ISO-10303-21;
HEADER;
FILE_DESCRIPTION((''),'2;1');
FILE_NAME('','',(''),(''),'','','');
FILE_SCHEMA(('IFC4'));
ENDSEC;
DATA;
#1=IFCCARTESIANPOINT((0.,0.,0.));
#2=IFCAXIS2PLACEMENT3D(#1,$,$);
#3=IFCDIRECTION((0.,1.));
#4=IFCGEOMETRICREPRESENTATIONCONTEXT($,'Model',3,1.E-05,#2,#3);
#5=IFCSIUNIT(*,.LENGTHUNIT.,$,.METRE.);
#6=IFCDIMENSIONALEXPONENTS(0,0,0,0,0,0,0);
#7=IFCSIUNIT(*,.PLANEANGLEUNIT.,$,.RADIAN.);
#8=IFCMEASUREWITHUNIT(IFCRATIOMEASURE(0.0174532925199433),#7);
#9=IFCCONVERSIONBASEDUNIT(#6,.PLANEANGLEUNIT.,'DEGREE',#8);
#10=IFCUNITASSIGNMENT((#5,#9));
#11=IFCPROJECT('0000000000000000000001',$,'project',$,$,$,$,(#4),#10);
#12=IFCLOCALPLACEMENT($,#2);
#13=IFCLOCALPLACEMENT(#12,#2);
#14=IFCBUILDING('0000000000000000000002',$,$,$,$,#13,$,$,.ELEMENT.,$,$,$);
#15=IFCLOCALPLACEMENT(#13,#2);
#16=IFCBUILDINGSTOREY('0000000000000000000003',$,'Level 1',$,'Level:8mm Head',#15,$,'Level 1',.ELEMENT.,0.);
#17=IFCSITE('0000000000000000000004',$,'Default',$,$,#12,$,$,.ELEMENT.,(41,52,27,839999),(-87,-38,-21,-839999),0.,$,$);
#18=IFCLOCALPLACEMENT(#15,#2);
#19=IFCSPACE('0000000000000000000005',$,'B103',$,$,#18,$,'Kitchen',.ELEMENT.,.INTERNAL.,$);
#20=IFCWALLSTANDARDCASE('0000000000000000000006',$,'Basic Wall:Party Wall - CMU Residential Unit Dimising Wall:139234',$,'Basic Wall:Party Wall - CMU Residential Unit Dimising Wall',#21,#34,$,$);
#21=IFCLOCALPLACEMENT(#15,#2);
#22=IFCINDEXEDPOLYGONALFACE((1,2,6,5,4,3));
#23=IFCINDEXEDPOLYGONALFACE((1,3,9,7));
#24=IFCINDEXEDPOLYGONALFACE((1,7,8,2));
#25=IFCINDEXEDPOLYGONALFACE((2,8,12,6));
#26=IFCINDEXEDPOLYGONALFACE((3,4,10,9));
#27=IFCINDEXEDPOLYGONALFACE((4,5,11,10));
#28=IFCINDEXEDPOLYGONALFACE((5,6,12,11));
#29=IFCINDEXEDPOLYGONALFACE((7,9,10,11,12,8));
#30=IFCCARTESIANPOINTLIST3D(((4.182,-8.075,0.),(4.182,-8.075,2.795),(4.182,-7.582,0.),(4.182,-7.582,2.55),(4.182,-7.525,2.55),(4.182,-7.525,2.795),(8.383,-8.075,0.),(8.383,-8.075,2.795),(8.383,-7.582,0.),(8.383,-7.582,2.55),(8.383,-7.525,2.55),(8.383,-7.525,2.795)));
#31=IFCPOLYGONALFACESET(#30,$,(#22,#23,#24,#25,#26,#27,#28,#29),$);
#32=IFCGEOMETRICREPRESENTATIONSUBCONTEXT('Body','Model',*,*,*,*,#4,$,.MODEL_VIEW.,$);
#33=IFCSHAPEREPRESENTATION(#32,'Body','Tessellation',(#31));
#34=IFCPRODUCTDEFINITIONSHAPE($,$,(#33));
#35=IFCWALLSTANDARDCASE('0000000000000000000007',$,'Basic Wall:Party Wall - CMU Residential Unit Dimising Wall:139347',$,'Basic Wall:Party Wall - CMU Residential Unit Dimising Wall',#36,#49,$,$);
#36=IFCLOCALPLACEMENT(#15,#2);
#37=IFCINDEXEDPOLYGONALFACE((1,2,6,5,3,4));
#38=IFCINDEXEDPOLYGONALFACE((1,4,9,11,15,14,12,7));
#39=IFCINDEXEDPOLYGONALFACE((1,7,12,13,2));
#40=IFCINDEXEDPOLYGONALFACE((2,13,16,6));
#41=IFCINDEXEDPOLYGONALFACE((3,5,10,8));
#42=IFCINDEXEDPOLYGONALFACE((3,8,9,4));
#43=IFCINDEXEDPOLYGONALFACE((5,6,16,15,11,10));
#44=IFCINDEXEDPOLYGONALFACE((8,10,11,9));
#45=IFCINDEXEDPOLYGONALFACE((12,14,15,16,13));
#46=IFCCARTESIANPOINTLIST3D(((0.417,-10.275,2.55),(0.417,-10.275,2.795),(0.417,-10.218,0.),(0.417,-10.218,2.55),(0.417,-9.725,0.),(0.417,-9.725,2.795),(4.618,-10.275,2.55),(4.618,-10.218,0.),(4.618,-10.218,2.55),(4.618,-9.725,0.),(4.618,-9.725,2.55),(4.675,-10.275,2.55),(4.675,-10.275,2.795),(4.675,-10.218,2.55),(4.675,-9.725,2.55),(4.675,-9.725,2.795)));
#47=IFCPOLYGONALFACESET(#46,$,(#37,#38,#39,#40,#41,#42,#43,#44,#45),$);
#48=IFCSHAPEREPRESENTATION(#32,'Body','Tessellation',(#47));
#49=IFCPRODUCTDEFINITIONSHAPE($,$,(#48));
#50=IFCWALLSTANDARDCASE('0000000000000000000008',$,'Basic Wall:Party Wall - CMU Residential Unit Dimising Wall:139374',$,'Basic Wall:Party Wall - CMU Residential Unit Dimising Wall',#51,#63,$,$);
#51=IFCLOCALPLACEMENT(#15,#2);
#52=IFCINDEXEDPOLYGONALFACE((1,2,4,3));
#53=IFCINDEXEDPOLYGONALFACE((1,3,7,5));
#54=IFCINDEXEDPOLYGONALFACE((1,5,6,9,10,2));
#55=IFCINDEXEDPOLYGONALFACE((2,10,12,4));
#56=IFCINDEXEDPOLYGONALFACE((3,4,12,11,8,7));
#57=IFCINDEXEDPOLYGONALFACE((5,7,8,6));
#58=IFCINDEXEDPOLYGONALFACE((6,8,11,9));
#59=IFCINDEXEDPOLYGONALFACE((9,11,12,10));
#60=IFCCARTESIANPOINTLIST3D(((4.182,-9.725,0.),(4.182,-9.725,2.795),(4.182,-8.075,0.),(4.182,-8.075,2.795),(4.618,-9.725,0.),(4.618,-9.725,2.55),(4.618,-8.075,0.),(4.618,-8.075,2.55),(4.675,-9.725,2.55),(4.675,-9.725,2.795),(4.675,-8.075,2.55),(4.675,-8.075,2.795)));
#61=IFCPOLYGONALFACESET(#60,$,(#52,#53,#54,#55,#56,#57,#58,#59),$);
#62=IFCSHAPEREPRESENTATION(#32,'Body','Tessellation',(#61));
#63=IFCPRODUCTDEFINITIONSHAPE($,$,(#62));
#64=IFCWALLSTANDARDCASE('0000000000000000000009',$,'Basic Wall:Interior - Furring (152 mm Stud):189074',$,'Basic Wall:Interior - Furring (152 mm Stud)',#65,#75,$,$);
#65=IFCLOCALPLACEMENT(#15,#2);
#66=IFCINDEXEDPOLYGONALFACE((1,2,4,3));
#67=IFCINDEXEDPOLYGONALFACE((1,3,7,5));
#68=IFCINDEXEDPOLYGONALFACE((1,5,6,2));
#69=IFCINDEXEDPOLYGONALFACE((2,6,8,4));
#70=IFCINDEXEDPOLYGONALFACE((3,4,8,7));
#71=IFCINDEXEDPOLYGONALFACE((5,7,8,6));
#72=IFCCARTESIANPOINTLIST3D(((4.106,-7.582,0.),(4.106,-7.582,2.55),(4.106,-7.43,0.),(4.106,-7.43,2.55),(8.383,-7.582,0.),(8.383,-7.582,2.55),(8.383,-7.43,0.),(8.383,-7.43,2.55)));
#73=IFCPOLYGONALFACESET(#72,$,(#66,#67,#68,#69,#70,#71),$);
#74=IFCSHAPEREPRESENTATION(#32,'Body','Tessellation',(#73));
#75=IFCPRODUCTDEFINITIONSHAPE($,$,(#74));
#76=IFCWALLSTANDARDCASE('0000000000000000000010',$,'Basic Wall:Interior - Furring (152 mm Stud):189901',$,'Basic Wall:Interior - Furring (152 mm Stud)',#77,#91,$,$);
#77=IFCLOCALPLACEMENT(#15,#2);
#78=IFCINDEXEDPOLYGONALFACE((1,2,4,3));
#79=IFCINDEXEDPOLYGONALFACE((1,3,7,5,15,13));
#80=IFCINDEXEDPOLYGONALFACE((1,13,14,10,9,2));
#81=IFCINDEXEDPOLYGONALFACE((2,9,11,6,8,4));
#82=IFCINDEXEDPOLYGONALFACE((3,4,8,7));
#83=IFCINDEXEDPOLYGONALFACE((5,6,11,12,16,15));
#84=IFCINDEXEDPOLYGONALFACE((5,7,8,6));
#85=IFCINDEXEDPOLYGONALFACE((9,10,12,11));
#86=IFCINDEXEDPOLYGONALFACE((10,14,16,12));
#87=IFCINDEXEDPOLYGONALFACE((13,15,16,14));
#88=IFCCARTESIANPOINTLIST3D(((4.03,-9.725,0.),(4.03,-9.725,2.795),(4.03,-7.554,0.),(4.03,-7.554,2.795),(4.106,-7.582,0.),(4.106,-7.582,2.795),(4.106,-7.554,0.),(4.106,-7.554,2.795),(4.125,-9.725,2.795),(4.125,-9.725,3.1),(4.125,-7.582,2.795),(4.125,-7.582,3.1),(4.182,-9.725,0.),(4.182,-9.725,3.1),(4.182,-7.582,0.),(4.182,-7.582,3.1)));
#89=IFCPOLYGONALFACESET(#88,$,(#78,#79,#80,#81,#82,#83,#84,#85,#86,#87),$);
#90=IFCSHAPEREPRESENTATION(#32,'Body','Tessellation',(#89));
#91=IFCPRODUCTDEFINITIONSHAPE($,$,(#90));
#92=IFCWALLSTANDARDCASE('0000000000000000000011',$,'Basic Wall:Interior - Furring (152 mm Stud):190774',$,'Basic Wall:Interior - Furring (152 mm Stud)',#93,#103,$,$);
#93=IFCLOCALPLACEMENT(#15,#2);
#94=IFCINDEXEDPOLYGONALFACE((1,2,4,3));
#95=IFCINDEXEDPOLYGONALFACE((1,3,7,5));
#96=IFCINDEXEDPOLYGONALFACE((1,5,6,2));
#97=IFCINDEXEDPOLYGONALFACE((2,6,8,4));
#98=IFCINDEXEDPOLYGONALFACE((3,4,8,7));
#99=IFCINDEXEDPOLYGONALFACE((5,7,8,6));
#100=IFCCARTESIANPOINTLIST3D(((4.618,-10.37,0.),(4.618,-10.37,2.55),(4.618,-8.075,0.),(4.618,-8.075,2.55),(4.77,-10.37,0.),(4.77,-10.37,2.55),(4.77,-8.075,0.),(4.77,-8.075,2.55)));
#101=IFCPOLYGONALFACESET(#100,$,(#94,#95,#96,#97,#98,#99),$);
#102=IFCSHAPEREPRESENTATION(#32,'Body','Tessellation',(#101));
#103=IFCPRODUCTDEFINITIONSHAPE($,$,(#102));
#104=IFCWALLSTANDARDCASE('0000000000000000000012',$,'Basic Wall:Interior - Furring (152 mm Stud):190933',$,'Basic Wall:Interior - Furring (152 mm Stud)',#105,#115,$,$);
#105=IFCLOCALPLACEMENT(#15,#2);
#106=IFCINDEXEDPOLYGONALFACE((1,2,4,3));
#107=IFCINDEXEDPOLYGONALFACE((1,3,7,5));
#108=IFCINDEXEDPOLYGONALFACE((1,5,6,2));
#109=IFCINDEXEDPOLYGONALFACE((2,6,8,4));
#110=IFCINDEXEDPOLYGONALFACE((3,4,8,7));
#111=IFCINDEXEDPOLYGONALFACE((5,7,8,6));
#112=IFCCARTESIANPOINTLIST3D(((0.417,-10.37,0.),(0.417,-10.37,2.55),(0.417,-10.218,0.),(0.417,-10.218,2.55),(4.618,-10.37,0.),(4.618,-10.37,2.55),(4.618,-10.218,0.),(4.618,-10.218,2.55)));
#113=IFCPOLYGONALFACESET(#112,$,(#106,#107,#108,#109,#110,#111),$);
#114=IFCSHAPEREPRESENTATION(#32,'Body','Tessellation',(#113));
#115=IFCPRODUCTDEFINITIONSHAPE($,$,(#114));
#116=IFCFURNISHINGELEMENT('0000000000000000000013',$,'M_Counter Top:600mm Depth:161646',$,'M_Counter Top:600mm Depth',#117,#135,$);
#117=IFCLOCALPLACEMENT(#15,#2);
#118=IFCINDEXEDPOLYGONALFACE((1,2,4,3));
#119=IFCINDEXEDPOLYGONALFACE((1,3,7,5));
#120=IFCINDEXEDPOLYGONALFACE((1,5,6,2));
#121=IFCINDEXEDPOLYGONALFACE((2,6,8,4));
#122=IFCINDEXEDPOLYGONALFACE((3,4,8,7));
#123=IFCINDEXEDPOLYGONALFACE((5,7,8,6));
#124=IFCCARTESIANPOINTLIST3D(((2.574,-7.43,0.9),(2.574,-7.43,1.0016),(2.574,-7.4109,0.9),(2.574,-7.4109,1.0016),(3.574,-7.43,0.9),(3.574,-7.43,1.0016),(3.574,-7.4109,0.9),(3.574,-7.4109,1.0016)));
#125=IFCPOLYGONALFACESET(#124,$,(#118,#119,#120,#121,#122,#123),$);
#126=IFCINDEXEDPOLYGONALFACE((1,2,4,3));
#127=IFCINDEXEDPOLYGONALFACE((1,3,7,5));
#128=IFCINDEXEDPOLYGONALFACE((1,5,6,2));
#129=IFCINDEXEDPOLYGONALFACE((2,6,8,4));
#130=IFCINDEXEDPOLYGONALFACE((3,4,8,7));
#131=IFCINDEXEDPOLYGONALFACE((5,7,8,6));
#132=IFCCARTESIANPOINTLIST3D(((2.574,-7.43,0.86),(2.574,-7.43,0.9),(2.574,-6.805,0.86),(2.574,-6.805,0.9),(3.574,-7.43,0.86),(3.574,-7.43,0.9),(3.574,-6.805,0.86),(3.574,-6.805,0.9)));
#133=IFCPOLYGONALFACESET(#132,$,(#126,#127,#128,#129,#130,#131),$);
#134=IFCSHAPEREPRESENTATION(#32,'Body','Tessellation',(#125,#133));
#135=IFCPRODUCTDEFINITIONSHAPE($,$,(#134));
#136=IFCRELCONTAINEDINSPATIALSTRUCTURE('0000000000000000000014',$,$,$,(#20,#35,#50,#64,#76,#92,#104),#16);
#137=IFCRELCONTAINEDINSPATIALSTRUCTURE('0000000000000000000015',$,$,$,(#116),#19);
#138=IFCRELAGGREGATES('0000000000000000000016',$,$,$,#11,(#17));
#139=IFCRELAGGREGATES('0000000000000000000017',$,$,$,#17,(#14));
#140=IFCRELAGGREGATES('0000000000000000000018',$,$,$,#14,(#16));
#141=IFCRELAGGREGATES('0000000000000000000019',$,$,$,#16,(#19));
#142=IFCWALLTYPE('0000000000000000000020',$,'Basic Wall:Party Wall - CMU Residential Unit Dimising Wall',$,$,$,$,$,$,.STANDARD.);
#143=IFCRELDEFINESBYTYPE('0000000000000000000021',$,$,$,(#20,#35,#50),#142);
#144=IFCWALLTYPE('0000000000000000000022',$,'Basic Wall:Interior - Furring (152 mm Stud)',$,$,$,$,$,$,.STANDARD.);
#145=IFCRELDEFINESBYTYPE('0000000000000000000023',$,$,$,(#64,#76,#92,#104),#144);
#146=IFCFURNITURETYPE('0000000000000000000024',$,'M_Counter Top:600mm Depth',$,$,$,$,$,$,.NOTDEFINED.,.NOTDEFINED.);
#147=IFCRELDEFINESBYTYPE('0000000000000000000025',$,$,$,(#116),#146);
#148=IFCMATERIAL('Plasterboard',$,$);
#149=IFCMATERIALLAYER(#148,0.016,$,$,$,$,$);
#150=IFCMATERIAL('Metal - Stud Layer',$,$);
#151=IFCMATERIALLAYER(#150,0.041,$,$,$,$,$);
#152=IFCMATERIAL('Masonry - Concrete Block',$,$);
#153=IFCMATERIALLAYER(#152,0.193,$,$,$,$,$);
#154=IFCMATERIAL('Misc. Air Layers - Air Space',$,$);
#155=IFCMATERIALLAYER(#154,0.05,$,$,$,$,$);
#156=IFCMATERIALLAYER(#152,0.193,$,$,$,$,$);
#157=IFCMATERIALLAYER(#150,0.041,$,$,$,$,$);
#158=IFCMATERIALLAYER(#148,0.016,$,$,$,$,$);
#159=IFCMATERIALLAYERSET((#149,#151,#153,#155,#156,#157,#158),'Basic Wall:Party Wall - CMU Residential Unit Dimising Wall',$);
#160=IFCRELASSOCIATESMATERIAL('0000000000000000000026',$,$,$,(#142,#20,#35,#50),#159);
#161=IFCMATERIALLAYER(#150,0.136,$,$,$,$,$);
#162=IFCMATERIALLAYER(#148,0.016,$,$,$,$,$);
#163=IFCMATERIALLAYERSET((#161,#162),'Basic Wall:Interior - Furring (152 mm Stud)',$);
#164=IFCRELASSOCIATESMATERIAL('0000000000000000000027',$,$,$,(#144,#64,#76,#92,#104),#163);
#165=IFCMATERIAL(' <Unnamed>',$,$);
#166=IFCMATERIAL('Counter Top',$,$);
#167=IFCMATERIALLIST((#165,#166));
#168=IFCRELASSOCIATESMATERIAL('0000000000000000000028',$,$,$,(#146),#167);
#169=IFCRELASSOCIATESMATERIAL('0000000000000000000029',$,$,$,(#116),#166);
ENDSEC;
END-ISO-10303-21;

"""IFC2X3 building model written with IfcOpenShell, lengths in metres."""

from ifc_helpers import new_model, entity, si_unit, converted_unit, direction, frame, frame_2d, origin, place, context, subcontext, project, spatial, polyline, rectangle, outline, extrude, clip, bounded_halfspace, source, transform, mapped, material, material_list, layer, layer_set, layer_usage, type_object, type_shapes, element, save


model = new_model("IFC2X3")

# Units and contexts
model_context = context("Model", 3, precision=1e-05, world=origin(), true_north=direction((0.0, 1.0)))
body_context = subcontext(model_context, "Body", "Model", "MODEL_VIEW")
ifc_project = project(units=[si_unit("LENGTHUNIT", "METRE"), converted_unit("PLANEANGLEUNIT", "DEGREE", entity("IfcRatioMeasure", 0.0174532925199433), si_unit("PLANEANGLEUNIT", "RADIAN"), dimensions=[0, 0, 0, 0, 0, 0, 0])], contexts=[model_context])

# Site, building, storey
site_placement = place(None, origin())
site = spatial("IfcSite", under=ifc_project, at=site_placement, Name="Default", CompositionType="ELEMENT", RefLatitude=(41, 52, 27, 839999), RefLongitude=(-87, -38, -21, -839999), RefElevation=0.0)
building_placement = place(site_placement, origin())
building = spatial("IfcBuilding", under=site, at=building_placement, CompositionType="ELEMENT")
storey_placement = place(building_placement, origin())
storey = spatial("IfcBuildingStorey", under=building, at=storey_placement, Name="Level 1", ObjectType="Level:8mm Head", LongName="Level 1", CompositionType="ELEMENT", Elevation=0.0)

# Shared definitions
ifc_material_1 = material(Name="Misc. Air Layers - Air Space")
ifc_material_2 = material(Name="Masonry - Concrete Block")
ifc_material_3 = material(Name="Metal - Stud Layer")
ifc_material_4 = material(Name="Plasterboard")

# Walls
ifc_layer_1 = layer(ifc_material_4, 0.016)
ifc_layer_2 = layer(ifc_material_3, 0.041)
ifc_layer_3 = layer(ifc_material_2, 0.193)
ifc_layer_4 = layer(ifc_material_1, 0.05)
ifc_layer_5 = layer(ifc_material_2, 0.193)
ifc_layer_6 = layer(ifc_material_3, 0.041)
ifc_layer_7 = layer(ifc_material_4, 0.016)
ifc_layer_set_1 = layer_set([ifc_layer_1, ifc_layer_2, ifc_layer_3, ifc_layer_4, ifc_layer_5, ifc_layer_6, ifc_layer_7], Name="Basic Wall:Party Wall - CMU Residential Unit Dimising Wall")
ifc_layer_usage_1 = layer_usage(ifc_layer_set_1, "AXIS2", "NEGATIVE", 0.275)
wall_type_1 = type_object("IfcWallType", Name="Basic Wall:Party Wall - CMU Residential Unit Dimising Wall", PredefinedType="STANDARD", material=ifc_layer_set_1)
wall_1_placement = place(storey_placement, frame((8.383, -7.8, 0.0), z_axis=(0.0, 0.0, 1.0), x_axis=(-1.0, 0.0, 0.0)))
element("IfcWallStandardCase", 1, at=wall_1_placement, inside=storey, type_object=wall_type_1, material=ifc_layer_usage_1, Name="Basic Wall:Party Wall - CMU Residential Unit Dimising Wall:139234", ObjectType="Basic Wall:Party Wall - CMU Residential Unit Dimising Wall", context=body_context, shape_type="Clipping", body=[
    clip(clip(extrude(rectangle(XDim=4.201, YDim=0.55, at=frame_2d((2.1005, 0.0), x_axis=(-1.0, 0.0))), origin(), (0.0, 0.0, 1.0), 2.795), bounded_halfspace(frame((4.201, -0.218, 2.55), z_axis=(0.0, 1.0, 0.0), x_axis=(-1.0, 0.0, 0.0)), True, frame((4.201, -0.218, 2.55), z_axis=(0.0, 1.0, 0.0), x_axis=(-1.0, 0.0, 0.0)), polyline([(0.0, 0.0), (0.0, -2.55), (4.201, -2.55), (4.201, 0.0), (0.0, 0.0)]))), bounded_halfspace(frame((0.0, -0.218, 2.55), z_axis=(0.0, 0.0, 1.0), x_axis=(0.0, 1.0, 0.0)), True, frame((0.0, -0.218, 2.55), z_axis=(0.0, 0.0, 1.0), x_axis=(0.0, 1.0, 0.0)), polyline([(0.0, 0.0), (-0.057, 0.0), (-0.057, -4.201), (0.0, -4.201), (0.0, 0.0)]))),
])
ifc_layer_usage_2 = layer_usage(ifc_layer_set_1, "AXIS2", "NEGATIVE", 0.275)
wall_2_placement = place(storey_placement, frame((0.417, -10.0, 0.0)))
element("IfcWallStandardCase", 2, at=wall_2_placement, inside=storey, type_object=wall_type_1, material=ifc_layer_usage_2, Name="Basic Wall:Party Wall - CMU Residential Unit Dimising Wall:139347", ObjectType="Basic Wall:Party Wall - CMU Residential Unit Dimising Wall", context=body_context, shape_type="Clipping", body=[
    clip(clip(clip(extrude(rectangle(XDim=4.258, YDim=0.55, at=frame_2d((2.129, 0.0), x_axis=(-1.0, 0.0))), origin(), (0.0, 0.0, 1.0), 2.795), bounded_halfspace(frame((4.201, -0.218, 2.55), z_axis=(0.0, 1.0, 0.0), x_axis=(-1.0, 0.0, 0.0)), True, frame((4.201, -0.218, 2.55), z_axis=(0.0, 1.0, 0.0), x_axis=(-1.0, 0.0, 0.0)), polyline([(0.0, 0.0), (0.0, -2.55), (4.201, -2.55), (4.201, 0.0), (0.0, 0.0)]))), bounded_halfspace(frame((0.0, -0.218, 2.55), z_axis=(0.0, 0.0, 1.0), x_axis=(0.0, 1.0, 0.0)), True, frame((0.0, -0.218, 2.55), z_axis=(0.0, 0.0, 1.0), x_axis=(0.0, 1.0, 0.0)), polyline([(0.0, 0.0), (-0.057, 0.0), (-0.057, -4.258), (0.493, -4.258), (0.493, -4.201), (0.0, -4.201), (0.0, 0.0)]))), bounded_halfspace(frame((4.201, 0.275, 2.55), z_axis=(-1.0, 0.0, 0.0), x_axis=(0.0, -1.0, 0.0)), True, frame((4.201, 0.275, 2.55), z_axis=(-1.0, 0.0, 0.0), x_axis=(0.0, -1.0, 0.0)), polyline([(0.0, 0.0), (0.0, -2.55), (0.493, -2.55), (0.493, 0.0), (0.0, 0.0)]))),
])
ifc_layer_usage_3 = layer_usage(ifc_layer_set_1, "AXIS2", "NEGATIVE", 0.275)
wall_3_placement = place(storey_placement, frame((4.4, -9.725, 0.0), z_axis=(0.0, 0.0, 1.0), x_axis=(0.0, 1.0, 0.0)))
element("IfcWallStandardCase", 3, at=wall_3_placement, inside=storey, type_object=wall_type_1, material=ifc_layer_usage_3, Name="Basic Wall:Party Wall - CMU Residential Unit Dimising Wall:139374", ObjectType="Basic Wall:Party Wall - CMU Residential Unit Dimising Wall", context=body_context, shape_type="Clipping", body=[
    clip(clip(clip(extrude(rectangle(XDim=1.65, YDim=0.55, at=frame_2d((0.825, 0.0), x_axis=(-1.0, 0.0))), origin(), (0.0, 0.0, 1.0), 2.795), bounded_halfspace(frame((1.65, 0.218, 0.0), z_axis=(0.0, -1.0, 0.0), x_axis=(1.0, 0.0, 0.0)), True, frame((1.65, 0.218, 0.0), z_axis=(0.0, -1.0, 0.0), x_axis=(1.0, 0.0, 0.0)), polyline([(0.0, 0.0), (0.0, 2.795), (-1.65, 2.795), (-1.65, 0.0), (0.0, 0.0)]))), bounded_halfspace(frame((1.65, -0.218, 2.55), z_axis=(0.0, 1.0, 0.0), x_axis=(-1.0, 0.0, 0.0)), True, frame((1.65, -0.218, 2.55), z_axis=(0.0, 1.0, 0.0), x_axis=(-1.0, 0.0, 0.0)), polyline([(0.0, 0.0), (0.0, -2.55), (1.65, -2.55), (1.65, 0.0), (0.0, 0.0)]))), bounded_halfspace(frame((0.0, -0.218, 2.55), z_axis=(0.0, 0.0, 1.0), x_axis=(0.0, -1.0, 0.0)), True, frame((0.0, -0.218, 2.55), z_axis=(0.0, 0.0, 1.0), x_axis=(0.0, -1.0, 0.0)), polyline([(0.0, 0.0), (0.057, 0.0), (0.057, 1.65), (0.0, 1.65), (0.0, 0.0)]))),
])
ifc_layer_8 = layer(ifc_material_3, 0.136)
ifc_layer_9 = layer(ifc_material_4, 0.016)
ifc_layer_set_2 = layer_set([ifc_layer_8, ifc_layer_9], Name="Basic Wall:Interior - Furring (152 mm Stud)")
ifc_layer_usage_4 = layer_usage(ifc_layer_set_2, "AXIS2", "NEGATIVE", 0.076)
wall_type_2 = type_object("IfcWallType", Name="Basic Wall:Interior - Furring (152 mm Stud)", PredefinedType="STANDARD", material=ifc_layer_set_2)
wall_4_placement = place(storey_placement, frame((8.383, -7.506, 0.0), z_axis=(0.0, 0.0, 1.0), x_axis=(-1.0, 0.0, 0.0)))
element("IfcWallStandardCase", 4, at=wall_4_placement, inside=storey, type_object=wall_type_2, material=ifc_layer_usage_4, Name="Basic Wall:Interior - Furring (152 mm Stud):189074", ObjectType="Basic Wall:Interior - Furring (152 mm Stud)", context=body_context, shape_type="SweptSolid", body=[
    extrude(rectangle(XDim=4.277, YDim=0.152, at=frame_2d((2.1385, 0.0), x_axis=(-1.0, 0.0))), origin(), (0.0, 0.0, 1.0), 2.55),
])
ifc_layer_usage_5 = layer_usage(ifc_layer_set_2, "AXIS2", "POSITIVE", -0.076)
wall_5_placement = place(storey_placement, frame((4.106, -9.725, 0.0), z_axis=(0.0, 0.0, 1.0), x_axis=(0.0, 1.0, 0.0)))
element("IfcWallStandardCase", 5, at=wall_5_placement, inside=storey, type_object=wall_type_2, material=ifc_layer_usage_5, Name="Basic Wall:Interior - Furring (152 mm Stud):189901", ObjectType="Basic Wall:Interior - Furring (152 mm Stud)", context=body_context, shape_type="Clipping", body=[
    clip(clip(extrude(outline(polyline([(2.143, -0.076), (2.143, 0.0), (2.171, 0.0), (2.171, 0.076), (0.0, 0.076), (0.0, -0.076), (1.65, -0.076), (2.143, -0.076)])), origin(), (0.0, 0.0, 1.0), 3.1), bounded_halfspace(frame((0.0, -0.019, 2.795), z_axis=(0.0, 0.0, -1.0), x_axis=(-1.0, 0.0, 0.0)), True, frame((0.0, -0.019, 2.795), z_axis=(0.0, 0.0, -1.0), x_axis=(-1.0, 0.0, 0.0)), polyline([(0.0, 0.0), (0.0, 0.095), (-2.2, 0.095), (-2.2, 0.0), (0.0, 0.0)]))), bounded_halfspace(frame((2.2, -0.019, 2.795), z_axis=(0.0, -1.0, 0.0), x_axis=(0.0, 0.0, 1.0)), True, frame((2.2, -0.019, 2.795), z_axis=(0.0, -1.0, 0.0), x_axis=(0.0, 0.0, 1.0)), polyline([(0.0, 0.0), (0.305, 0.0), (0.305, 2.2), (0.0, 2.2), (0.0, 0.0)]))),
])
ifc_layer_usage_6 = layer_usage(ifc_layer_set_2, "AXIS2", "POSITIVE", -0.076)
wall_6_placement = place(storey_placement, frame((4.694, -8.075, 0.0), z_axis=(0.0, 0.0, 1.0), x_axis=(0.0, -1.0, 0.0)))
element("IfcWallStandardCase", 6, at=wall_6_placement, inside=storey, type_object=wall_type_2, material=ifc_layer_usage_6, Name="Basic Wall:Interior - Furring (152 mm Stud):190774", ObjectType="Basic Wall:Interior - Furring (152 mm Stud)", context=body_context, shape_type="SweptSolid", body=[
    extrude(rectangle(XDim=2.295, YDim=0.152, at=frame_2d((1.1475, 0.0), x_axis=(-1.0, 0.0))), origin(), (0.0, 0.0, 1.0), 2.55),
])
ifc_layer_usage_7 = layer_usage(ifc_layer_set_2, "AXIS2", "NEGATIVE", 0.076)
wall_7_placement = place(storey_placement, frame((0.417, -10.294, 0.0)))
element("IfcWallStandardCase", 7, at=wall_7_placement, inside=storey, type_object=wall_type_2, material=ifc_layer_usage_7, Name="Basic Wall:Interior - Furring (152 mm Stud):190933", ObjectType="Basic Wall:Interior - Furring (152 mm Stud)", context=body_context, shape_type="SweptSolid", body=[
    extrude(rectangle(XDim=4.201, YDim=0.152, at=frame_2d((2.1005, 0.0), x_axis=(-1.0, 0.0))), origin(), (0.0, 0.0, 1.0), 2.55),
])

# Shared definitions
space_1_placement = place(storey_placement, origin())
space_1 = spatial("IfcSpace", under=storey, at=space_1_placement, Name="B103", LongName="Kitchen", CompositionType="ELEMENT", InteriorOrExteriorSpace="INTERNAL")

# Shared definitions
ifc_material_5 = material(Name="Counter Top")
ifc_material_6 = material(Name=" <Unnamed>")

# Furnishing element
ifc_material_list_1 = material_list([ifc_material_6, ifc_material_5])
furniture_type_1 = type_object("IfcFurnitureType", Name="M_Counter Top:600mm Depth", material=ifc_material_list_1)
shared_shape_1 = source(origin(), body_context, "Body", "SweptSolid", [
    extrude(rectangle(XDim=0.0191, YDim=1.0, at=frame_2d((0.0, 0.0), x_axis=(1.0, 0.0))), frame((-0.7005, -0.0095, 0.9), z_axis=(0.0, 0.0, 1.0), x_axis=(0.0, -1.0, 0.0)), (0.0, 0.0, 1.0), 0.1016),
    extrude(rectangle(XDim=1.0, YDim=0.625, at=frame_2d((0.0, 0.0), x_axis=(1.0, 0.0))), frame((-0.7005, -0.3125, 0.86), z_axis=(0.0, 0.0, 1.0), x_axis=(-1.0, 0.0, 0.0)), (0.0, 0.0, 1.0), 0.04),
])
type_shapes(furniture_type_1, [shared_shape_1])
furnishing_1_placement = place(space_1_placement, frame((2.3735, -7.43, 0.0), z_axis=(0.0, 0.0, 1.0), x_axis=(-1.0, 0.0, 0.0)))
element("IfcFurnishingElement", 8, at=furnishing_1_placement, inside=space_1, type_object=furniture_type_1, material=ifc_material_5, Name="M_Counter Top:600mm Depth:161646", ObjectType="M_Counter Top:600mm Depth", context=body_context, shape_type="MappedRepresentation", body=[
    mapped(shared_shape_1, transform((0.0, 0.0, 0.0), scale=1.0)),
])

save(model, "model.ifc")
